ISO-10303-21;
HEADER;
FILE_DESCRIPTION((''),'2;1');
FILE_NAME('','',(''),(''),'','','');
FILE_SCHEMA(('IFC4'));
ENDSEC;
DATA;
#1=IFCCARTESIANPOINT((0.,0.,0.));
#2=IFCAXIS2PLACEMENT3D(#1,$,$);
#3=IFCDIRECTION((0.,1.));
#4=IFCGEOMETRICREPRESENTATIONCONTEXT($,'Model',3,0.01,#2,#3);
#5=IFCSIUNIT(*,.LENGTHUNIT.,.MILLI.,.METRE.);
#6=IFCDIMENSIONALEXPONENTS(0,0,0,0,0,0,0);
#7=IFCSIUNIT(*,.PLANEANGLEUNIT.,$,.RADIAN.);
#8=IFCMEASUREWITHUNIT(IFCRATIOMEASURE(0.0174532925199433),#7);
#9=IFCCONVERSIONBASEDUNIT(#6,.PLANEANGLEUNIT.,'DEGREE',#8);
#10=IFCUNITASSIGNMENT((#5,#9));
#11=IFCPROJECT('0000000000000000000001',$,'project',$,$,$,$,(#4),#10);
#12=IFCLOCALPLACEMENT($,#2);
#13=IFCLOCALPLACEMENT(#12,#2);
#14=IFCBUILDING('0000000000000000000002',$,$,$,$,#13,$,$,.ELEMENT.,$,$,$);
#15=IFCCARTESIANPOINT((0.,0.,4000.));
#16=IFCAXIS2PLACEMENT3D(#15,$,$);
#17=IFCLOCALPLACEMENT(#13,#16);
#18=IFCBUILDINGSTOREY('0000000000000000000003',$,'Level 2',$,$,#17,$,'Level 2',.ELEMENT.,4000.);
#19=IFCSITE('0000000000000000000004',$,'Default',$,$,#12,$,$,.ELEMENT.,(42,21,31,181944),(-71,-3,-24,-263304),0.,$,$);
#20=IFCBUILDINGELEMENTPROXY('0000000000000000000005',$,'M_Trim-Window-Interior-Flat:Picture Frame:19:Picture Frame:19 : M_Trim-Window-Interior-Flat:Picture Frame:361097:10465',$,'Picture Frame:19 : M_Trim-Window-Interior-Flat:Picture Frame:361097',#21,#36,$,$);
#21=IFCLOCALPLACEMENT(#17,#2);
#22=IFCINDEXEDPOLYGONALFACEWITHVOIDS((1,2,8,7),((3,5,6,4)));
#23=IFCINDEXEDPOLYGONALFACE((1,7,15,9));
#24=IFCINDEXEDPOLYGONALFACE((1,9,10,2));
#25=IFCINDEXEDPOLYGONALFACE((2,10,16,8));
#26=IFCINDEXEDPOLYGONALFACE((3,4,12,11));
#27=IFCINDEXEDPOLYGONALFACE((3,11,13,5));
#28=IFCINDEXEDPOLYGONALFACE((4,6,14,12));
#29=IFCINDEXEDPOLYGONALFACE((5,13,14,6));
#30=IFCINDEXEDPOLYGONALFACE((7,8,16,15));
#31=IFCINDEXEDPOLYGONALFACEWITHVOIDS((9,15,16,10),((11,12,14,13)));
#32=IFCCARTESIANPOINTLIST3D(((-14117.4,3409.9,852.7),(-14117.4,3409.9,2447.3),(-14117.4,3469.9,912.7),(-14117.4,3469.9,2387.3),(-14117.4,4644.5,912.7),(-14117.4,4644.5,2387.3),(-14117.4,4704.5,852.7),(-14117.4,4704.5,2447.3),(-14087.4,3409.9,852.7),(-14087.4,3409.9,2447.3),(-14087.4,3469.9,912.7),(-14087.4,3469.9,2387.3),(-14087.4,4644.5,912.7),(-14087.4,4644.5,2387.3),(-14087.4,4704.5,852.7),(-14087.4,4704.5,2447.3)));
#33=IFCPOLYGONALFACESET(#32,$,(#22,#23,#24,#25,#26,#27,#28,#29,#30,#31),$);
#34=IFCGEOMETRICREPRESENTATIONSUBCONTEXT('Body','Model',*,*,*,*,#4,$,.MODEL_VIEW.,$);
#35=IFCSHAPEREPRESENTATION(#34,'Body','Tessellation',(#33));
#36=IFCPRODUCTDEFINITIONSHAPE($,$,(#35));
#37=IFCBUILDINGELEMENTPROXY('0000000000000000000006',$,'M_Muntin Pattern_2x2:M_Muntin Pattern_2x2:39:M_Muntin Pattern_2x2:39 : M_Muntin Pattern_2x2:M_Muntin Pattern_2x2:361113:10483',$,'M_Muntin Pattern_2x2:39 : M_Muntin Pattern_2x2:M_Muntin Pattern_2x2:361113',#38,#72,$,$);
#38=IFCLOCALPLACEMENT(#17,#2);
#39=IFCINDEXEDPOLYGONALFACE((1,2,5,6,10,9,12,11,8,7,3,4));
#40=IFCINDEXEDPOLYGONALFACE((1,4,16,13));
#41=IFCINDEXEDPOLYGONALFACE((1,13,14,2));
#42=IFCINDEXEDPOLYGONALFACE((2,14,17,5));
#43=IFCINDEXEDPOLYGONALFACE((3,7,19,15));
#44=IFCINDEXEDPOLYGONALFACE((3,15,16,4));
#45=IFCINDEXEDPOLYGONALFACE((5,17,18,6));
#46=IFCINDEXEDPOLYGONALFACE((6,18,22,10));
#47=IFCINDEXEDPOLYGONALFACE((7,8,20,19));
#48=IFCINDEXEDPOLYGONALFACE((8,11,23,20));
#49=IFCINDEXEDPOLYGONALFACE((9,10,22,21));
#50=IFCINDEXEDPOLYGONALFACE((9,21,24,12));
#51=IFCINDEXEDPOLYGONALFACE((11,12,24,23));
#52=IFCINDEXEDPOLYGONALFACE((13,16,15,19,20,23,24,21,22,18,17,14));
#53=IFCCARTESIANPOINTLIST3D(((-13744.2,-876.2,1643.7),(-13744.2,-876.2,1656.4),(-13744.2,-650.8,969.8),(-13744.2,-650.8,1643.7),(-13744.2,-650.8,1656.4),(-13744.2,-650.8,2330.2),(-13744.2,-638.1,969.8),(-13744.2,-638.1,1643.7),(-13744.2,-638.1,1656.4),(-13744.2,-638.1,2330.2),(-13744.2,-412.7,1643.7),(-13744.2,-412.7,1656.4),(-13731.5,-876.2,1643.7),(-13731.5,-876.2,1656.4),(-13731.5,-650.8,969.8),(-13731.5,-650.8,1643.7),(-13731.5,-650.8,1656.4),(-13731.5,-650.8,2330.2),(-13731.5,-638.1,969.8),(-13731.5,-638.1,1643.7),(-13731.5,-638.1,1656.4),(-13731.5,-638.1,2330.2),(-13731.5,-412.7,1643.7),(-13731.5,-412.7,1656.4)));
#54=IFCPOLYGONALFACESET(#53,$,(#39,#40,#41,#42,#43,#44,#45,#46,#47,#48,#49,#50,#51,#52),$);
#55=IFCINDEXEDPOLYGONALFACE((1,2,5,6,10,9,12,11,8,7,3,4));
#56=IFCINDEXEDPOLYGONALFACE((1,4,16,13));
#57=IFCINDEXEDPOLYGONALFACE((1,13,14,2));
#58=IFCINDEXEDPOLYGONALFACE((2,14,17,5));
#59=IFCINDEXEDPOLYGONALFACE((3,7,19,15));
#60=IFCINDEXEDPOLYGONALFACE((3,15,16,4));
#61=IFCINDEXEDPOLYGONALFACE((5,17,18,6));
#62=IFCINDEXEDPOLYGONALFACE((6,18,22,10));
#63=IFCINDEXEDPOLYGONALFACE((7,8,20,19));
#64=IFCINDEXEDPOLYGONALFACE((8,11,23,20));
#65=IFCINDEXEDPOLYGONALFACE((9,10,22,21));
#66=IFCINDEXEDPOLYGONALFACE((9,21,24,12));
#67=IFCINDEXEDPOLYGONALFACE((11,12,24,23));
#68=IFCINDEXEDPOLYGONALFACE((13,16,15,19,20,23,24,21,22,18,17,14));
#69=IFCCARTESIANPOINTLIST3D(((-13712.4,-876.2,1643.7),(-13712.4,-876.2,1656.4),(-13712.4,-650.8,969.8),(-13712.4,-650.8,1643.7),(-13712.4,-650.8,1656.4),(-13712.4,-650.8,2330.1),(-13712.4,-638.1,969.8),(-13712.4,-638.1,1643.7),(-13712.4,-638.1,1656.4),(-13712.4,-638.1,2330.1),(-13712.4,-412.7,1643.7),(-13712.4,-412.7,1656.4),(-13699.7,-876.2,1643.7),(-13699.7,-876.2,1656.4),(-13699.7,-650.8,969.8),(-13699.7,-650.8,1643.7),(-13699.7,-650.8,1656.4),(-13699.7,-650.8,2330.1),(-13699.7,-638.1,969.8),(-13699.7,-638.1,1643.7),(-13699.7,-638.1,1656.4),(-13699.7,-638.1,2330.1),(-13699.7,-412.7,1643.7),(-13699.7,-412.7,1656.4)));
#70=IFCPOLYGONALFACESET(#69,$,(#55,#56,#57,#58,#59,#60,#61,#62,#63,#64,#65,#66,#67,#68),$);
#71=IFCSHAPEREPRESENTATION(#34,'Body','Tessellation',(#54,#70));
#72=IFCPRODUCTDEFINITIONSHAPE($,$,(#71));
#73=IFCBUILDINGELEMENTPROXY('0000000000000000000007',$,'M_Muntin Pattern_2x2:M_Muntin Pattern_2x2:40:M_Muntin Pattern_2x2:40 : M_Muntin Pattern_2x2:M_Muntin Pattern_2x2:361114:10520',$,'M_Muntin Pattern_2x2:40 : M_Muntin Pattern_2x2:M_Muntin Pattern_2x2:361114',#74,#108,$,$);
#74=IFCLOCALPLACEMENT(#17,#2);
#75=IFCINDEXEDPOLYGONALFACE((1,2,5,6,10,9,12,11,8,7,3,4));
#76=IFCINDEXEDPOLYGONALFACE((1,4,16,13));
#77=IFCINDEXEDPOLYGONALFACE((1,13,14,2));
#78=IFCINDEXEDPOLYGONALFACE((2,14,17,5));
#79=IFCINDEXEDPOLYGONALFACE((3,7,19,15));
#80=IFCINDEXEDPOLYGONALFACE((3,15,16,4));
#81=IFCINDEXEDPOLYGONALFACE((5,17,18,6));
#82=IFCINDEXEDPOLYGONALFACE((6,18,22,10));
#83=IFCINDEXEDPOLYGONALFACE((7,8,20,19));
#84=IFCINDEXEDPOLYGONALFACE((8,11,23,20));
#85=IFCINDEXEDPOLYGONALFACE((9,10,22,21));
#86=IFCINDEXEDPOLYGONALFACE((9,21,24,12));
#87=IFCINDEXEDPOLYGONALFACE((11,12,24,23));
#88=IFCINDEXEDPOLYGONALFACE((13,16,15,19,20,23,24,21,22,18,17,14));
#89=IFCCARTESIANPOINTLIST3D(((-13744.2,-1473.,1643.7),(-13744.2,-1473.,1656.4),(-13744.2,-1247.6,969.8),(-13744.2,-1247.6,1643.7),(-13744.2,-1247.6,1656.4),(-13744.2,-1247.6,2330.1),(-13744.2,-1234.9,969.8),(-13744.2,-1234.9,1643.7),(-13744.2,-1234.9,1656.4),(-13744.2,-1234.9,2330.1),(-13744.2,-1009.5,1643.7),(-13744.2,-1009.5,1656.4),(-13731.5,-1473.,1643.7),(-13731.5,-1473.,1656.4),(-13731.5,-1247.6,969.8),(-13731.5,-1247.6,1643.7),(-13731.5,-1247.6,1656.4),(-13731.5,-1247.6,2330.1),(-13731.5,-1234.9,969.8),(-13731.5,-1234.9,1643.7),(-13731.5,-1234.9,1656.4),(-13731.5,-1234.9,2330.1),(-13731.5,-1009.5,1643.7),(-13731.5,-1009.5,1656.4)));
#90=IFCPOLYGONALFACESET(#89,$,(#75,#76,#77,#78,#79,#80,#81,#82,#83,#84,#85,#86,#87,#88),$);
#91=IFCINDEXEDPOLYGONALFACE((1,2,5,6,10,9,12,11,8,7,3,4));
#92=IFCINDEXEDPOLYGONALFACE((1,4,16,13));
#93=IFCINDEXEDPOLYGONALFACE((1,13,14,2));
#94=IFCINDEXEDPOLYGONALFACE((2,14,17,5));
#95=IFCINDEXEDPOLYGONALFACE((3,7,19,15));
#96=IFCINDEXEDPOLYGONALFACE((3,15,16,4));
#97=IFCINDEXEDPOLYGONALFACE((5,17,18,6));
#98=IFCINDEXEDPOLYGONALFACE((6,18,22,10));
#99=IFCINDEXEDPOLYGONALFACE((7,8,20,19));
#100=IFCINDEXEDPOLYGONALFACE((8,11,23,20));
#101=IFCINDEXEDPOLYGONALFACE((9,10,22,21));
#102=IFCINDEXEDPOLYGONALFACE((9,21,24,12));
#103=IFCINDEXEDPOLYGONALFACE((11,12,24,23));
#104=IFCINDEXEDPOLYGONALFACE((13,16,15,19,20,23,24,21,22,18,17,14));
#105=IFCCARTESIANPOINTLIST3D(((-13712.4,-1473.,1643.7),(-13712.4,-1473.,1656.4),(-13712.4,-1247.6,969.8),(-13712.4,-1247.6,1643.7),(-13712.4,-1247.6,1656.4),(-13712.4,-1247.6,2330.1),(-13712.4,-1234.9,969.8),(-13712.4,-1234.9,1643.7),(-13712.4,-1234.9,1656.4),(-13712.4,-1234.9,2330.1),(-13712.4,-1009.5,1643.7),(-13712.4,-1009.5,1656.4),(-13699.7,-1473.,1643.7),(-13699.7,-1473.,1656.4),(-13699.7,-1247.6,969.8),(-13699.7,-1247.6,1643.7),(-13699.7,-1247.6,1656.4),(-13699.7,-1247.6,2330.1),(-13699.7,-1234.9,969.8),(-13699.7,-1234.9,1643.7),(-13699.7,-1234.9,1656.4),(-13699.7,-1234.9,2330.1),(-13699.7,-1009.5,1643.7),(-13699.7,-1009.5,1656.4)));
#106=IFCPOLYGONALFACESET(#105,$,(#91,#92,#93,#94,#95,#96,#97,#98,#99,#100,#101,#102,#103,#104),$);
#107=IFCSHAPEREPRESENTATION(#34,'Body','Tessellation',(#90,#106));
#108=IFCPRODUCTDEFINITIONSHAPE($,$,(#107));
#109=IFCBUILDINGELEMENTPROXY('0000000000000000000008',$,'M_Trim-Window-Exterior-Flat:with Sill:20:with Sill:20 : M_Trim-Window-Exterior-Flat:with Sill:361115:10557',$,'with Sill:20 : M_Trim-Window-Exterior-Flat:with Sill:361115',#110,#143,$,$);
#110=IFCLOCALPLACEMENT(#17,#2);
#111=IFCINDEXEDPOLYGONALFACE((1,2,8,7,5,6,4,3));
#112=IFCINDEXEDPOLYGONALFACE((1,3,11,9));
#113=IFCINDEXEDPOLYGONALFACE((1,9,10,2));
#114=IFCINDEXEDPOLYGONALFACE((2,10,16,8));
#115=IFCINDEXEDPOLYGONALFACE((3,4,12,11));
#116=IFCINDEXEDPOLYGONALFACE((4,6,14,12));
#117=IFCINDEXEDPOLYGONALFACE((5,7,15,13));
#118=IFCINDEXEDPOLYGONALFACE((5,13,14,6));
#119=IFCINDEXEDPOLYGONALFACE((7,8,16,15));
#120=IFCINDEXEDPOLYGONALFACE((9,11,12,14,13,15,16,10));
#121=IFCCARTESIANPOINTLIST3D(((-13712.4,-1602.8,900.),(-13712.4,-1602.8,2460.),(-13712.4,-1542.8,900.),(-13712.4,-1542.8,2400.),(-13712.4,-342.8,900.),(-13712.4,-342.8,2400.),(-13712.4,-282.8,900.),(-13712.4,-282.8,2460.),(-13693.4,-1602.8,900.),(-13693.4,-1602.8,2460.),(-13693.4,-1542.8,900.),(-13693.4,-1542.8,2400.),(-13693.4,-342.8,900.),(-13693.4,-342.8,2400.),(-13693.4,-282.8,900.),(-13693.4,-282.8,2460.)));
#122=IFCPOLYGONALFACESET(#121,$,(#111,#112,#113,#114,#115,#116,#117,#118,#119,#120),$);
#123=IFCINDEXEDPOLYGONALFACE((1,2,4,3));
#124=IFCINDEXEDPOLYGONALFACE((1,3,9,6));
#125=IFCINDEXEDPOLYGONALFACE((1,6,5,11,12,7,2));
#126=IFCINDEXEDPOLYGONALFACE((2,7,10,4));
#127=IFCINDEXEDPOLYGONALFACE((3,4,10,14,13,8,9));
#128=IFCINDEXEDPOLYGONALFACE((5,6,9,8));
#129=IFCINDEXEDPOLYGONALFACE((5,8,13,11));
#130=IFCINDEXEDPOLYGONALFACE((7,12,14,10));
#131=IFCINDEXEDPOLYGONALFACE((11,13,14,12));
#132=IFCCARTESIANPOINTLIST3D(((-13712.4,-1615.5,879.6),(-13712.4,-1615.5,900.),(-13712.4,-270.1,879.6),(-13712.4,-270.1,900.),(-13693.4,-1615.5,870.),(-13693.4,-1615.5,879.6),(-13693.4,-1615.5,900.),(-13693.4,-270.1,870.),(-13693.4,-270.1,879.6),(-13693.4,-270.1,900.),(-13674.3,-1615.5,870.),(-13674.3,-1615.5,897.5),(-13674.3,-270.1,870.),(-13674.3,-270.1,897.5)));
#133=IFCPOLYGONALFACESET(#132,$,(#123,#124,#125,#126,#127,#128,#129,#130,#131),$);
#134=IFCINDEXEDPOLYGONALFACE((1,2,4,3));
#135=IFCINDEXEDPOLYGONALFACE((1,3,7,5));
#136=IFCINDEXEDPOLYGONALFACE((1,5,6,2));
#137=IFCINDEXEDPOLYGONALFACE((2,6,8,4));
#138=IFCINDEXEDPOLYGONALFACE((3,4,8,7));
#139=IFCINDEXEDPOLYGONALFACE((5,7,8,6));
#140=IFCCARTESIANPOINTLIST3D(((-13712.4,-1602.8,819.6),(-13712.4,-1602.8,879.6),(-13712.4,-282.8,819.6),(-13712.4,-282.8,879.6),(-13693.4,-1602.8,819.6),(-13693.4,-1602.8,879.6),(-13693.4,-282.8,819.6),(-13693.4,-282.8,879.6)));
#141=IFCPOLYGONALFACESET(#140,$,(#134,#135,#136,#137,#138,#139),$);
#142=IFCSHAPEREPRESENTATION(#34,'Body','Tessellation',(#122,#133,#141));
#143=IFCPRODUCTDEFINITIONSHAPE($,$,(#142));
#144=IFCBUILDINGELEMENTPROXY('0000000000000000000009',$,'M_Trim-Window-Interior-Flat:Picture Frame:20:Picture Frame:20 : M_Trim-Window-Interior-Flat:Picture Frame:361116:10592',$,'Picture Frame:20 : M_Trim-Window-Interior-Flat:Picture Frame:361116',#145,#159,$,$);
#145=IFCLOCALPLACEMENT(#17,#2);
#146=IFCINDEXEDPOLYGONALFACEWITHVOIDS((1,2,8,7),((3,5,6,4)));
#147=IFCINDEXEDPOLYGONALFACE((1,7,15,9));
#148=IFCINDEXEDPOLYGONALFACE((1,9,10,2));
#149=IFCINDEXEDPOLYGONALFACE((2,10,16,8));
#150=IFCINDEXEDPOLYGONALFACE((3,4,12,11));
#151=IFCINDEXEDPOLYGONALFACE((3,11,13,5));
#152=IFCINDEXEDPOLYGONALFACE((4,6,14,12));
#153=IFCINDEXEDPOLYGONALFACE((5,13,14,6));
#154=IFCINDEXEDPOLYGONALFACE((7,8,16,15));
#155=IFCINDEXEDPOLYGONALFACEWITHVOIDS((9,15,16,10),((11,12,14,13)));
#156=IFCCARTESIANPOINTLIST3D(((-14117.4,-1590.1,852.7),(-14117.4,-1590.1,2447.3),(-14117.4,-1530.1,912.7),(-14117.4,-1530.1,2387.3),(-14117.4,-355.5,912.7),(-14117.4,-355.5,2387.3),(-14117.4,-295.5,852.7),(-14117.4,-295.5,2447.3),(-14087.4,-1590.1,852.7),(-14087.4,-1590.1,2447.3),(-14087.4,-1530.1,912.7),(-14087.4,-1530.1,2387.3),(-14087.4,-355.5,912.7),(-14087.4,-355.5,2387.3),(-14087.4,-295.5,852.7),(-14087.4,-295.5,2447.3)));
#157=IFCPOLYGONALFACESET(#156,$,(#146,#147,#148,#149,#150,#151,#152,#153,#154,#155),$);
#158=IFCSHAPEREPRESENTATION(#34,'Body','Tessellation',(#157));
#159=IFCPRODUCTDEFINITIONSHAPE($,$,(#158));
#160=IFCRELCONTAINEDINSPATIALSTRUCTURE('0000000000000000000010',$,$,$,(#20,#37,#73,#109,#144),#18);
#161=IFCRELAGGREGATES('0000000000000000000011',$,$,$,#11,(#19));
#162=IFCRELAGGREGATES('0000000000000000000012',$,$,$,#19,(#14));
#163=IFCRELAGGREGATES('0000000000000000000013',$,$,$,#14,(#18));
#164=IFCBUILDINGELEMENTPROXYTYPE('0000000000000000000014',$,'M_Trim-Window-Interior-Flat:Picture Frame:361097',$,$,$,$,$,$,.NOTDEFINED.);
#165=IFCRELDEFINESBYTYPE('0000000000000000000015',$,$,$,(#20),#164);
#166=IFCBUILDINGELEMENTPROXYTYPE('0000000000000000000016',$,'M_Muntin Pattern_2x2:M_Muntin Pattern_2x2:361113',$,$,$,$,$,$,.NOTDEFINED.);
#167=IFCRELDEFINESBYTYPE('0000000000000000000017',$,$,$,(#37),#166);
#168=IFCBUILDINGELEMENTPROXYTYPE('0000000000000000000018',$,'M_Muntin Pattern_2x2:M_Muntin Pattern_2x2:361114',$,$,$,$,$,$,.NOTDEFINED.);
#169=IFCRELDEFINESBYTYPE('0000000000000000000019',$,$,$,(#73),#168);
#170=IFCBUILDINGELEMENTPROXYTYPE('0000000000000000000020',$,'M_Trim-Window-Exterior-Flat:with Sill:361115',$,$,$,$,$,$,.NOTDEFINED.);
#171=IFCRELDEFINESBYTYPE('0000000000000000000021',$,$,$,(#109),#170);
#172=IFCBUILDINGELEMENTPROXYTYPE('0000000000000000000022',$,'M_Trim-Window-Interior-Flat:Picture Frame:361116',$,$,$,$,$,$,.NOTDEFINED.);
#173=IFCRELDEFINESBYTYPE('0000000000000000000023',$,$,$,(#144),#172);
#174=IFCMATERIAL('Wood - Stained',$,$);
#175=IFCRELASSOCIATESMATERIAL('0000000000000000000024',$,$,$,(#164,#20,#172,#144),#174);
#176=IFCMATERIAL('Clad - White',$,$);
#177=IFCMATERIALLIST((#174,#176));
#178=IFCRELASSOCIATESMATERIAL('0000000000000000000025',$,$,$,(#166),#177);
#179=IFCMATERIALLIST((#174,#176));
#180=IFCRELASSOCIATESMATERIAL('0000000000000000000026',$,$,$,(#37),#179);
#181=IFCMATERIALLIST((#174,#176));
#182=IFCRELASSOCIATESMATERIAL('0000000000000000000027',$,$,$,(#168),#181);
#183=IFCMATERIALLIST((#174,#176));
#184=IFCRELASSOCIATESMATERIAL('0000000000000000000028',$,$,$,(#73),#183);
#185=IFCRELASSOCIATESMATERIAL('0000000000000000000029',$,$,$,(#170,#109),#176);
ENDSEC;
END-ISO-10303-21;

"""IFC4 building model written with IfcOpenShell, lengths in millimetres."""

from ifc_helpers import new_model, entity, si_unit, converted_unit, direction, frame, origin, origin_2d_with_axis, place, context, subcontext, project, spatial, polyline, rectangle, outline, extrude, source, transform, mapped, material, material_list, type_object, type_shapes, element, save


model = new_model("IFC4")

# Units and contexts
model_context = context("Model", 3, precision=0.01, world=origin(), true_north=direction((0.0, 1.0)))
body_context = subcontext(model_context, "Body", "Model", "MODEL_VIEW")
ifc_project = project(units=[si_unit("LENGTHUNIT", "METRE", prefix="MILLI"), converted_unit("PLANEANGLEUNIT", "DEGREE", entity("IfcRatioMeasure", 0.0174532925199433), si_unit("PLANEANGLEUNIT", "RADIAN"), dimensions=[0, 0, 0, 0, 0, 0, 0])], contexts=[model_context])

# Site, building, storey
site_placement = place(None, origin())
site = spatial("IfcSite", under=ifc_project, at=site_placement, Name="Default", CompositionType="ELEMENT", RefLatitude=(42, 21, 31, 181944), RefLongitude=(-71, -3, -24, -263304), RefElevation=0.0)
building_placement = place(site_placement, origin())
building = spatial("IfcBuilding", under=site, at=building_placement, CompositionType="ELEMENT")
storey_placement = place(building_placement, frame((0.0, 0.0, 4000.0)))
storey = spatial("IfcBuildingStorey", under=building, at=storey_placement, Name="Level 2", LongName="Level 2", CompositionType="ELEMENT", Elevation=4000.0)

# Building element proxies
ifc_material_1 = material(Name="Wood - Stained")
building_element_proxy_type_1 = type_object("IfcBuildingElementProxyType", Name="M_Trim-Window-Interior-Flat:Picture Frame:361097", PredefinedType="NOTDEFINED", material=ifc_material_1)
shared_shape_1 = source(origin(), body_context, "Body", "SweptSolid", [
    extrude(outline(polyline([(-647.3, -797.3), (647.3, -797.3), (647.3, 797.3), (-647.3, 797.3), (-647.3, -797.3)]), holes=[polyline([(587.3, 737.3), (587.3, -737.3), (-587.3, -737.3), (-587.3, 737.3), (587.3, 737.3)])]), frame((-14117.4, 4057.2, 5650.0), z_axis=(1.0, 0.0, 0.0), x_axis=(0.0, -1.0, 0.0)), (0.0, 0.0, 1.0), 30.0),
])
type_shapes(building_element_proxy_type_1, [shared_shape_1])
proxy_1_placement = place(storey_placement, frame((0.0, 0.0, -4000.0)))
element("IfcBuildingElementProxy", 1, at=proxy_1_placement, inside=storey, type_object=building_element_proxy_type_1, material=ifc_material_1, Name="M_Trim-Window-Interior-Flat:Picture Frame:19:Picture Frame:19 : M_Trim-Window-Interior-Flat:Picture Frame:361097:10465", ObjectType="Picture Frame:19 : M_Trim-Window-Interior-Flat:Picture Frame:361097", context=body_context, shape_type="MappedRepresentation", body=[
    mapped(shared_shape_1, transform((0.0, 0.0, 0.0), scale=1.0)),
])
ifc_material_2 = material(Name="Clad - White")
ifc_material_list_1 = material_list([ifc_material_1, ifc_material_2])
ifc_material_list_2 = material_list([ifc_material_1, ifc_material_2])
building_element_proxy_type_2 = type_object("IfcBuildingElementProxyType", Name="M_Muntin Pattern_2x2:M_Muntin Pattern_2x2:361113", PredefinedType="NOTDEFINED", material=ifc_material_list_2)
shared_shape_2 = source(origin(), body_context, "Body", "SweptSolid", [
    extrude(outline(polyline([(-6.4, -680.2), (6.3, -680.2), (6.3, -6.4), (231.7, -6.4), (231.7, 6.3), (6.3, 6.3), (6.3, 680.2), (-6.4, 680.2), (-6.4, 6.3), (-231.7, 6.3), (-231.7, -6.4), (-6.4, -6.4), (-6.4, -680.2)])), frame((-13744.2, -644.4, 5650.0), z_axis=(1.0, 0.0, 0.0), x_axis=(0.0, -1.0, 0.0)), (0.0, 0.0, 1.0), 12.7),
    extrude(outline(polyline([(-6.4, -680.1), (6.3, -680.1), (6.3, -6.4), (231.7, -6.4), (231.7, 6.3), (6.3, 6.3), (6.3, 680.2), (-6.4, 680.2), (-6.4, 6.3), (-231.7, 6.3), (-231.7, -6.4), (-6.4, -6.4), (-6.4, -680.1)])), frame((-13712.4, -644.4, 5650.0), z_axis=(1.0, 0.0, 0.0), x_axis=(0.0, -1.0, 0.0)), (0.0, 0.0, 1.0), 12.7),
])
type_shapes(building_element_proxy_type_2, [shared_shape_2])
proxy_2_placement = place(storey_placement, frame((0.0, 0.0, -4000.0)))
element("IfcBuildingElementProxy", 2, at=proxy_2_placement, inside=storey, type_object=building_element_proxy_type_2, material=ifc_material_list_1, Name="M_Muntin Pattern_2x2:M_Muntin Pattern_2x2:39:M_Muntin Pattern_2x2:39 : M_Muntin Pattern_2x2:M_Muntin Pattern_2x2:361113:10483", ObjectType="M_Muntin Pattern_2x2:39 : M_Muntin Pattern_2x2:M_Muntin Pattern_2x2:361113", context=body_context, shape_type="MappedRepresentation", body=[
    mapped(shared_shape_2, transform((0.0, 0.0, 0.0), scale=1.0)),
])
ifc_material_list_3 = material_list([ifc_material_1, ifc_material_2])
ifc_material_list_4 = material_list([ifc_material_1, ifc_material_2])
building_element_proxy_type_3 = type_object("IfcBuildingElementProxyType", Name="M_Muntin Pattern_2x2:M_Muntin Pattern_2x2:361114", PredefinedType="NOTDEFINED", material=ifc_material_list_4)
shared_shape_3 = source(origin(), body_context, "Body", "SweptSolid", [
    extrude(outline(polyline([(-680.1, 6.4), (-680.1, -6.3), (-6.4, -6.3), (-6.4, -231.7), (6.3, -231.7), (6.3, -6.3), (680.2, -6.3), (680.2, 6.4), (6.3, 6.4), (6.3, 231.7), (-6.4, 231.7), (-6.4, 6.4), (-680.1, 6.4)])), frame((-13744.2, -1241.3, 5650.0), z_axis=(-1.0, 0.0, 0.0), x_axis=(0.0, 0.0, -1.0)), (0.0, 0.0, -1.0), 12.7),
    extrude(outline(polyline([(-680.1, 6.4), (-680.1, -6.3), (-6.4, -6.3), (-6.4, -231.7), (6.3, -231.7), (6.3, -6.3), (680.2, -6.3), (680.2, 6.4), (6.3, 6.4), (6.3, 231.7), (-6.4, 231.7), (-6.4, 6.4), (-680.1, 6.4)])), frame((-13712.4, -1241.3, 5650.0), z_axis=(-1.0, 0.0, 0.0), x_axis=(0.0, 0.0, -1.0)), (0.0, 0.0, -1.0), 12.7),
])
type_shapes(building_element_proxy_type_3, [shared_shape_3])
proxy_3_placement = place(storey_placement, frame((0.0, 0.0, -4000.0)))
element("IfcBuildingElementProxy", 3, at=proxy_3_placement, inside=storey, type_object=building_element_proxy_type_3, material=ifc_material_list_3, Name="M_Muntin Pattern_2x2:M_Muntin Pattern_2x2:40:M_Muntin Pattern_2x2:40 : M_Muntin Pattern_2x2:M_Muntin Pattern_2x2:361114:10520", ObjectType="M_Muntin Pattern_2x2:40 : M_Muntin Pattern_2x2:M_Muntin Pattern_2x2:361114", context=body_context, shape_type="MappedRepresentation", body=[
    mapped(shared_shape_3, transform((0.0, 0.0, 0.0), scale=1.0)),
])
building_element_proxy_type_4 = type_object("IfcBuildingElementProxyType", Name="M_Trim-Window-Exterior-Flat:with Sill:361115", PredefinedType="NOTDEFINED", material=ifc_material_2)
shared_shape_4 = source(origin(), body_context, "Body", "SweptSolid", [
    extrude(outline(polyline([(-660.0, -765.0), (-600.0, -765.0), (-600.0, 735.0), (600.0, 735.0), (600.0, -765.0), (660.0, -765.0), (660.0, 795.0), (-660.0, 795.0), (-660.0, -765.0)])), frame((-13712.4, -942.8, 5665.0), z_axis=(1.0, 0.0, 0.0), x_axis=(0.0, 1.0, 0.0)), (0.0, 0.0, 1.0), 19.1),
    extrude(outline(polyline([(-15.2, 0.0), (-15.2, -19.0), (12.3, -19.0), (14.8, 0.0), (14.8, 19.0), (-5.7, 19.0), (-5.7, 0.0), (-15.2, 0.0)])), frame((-13693.4, -1615.5, 4885.2), z_axis=(0.0, -1.0, 0.0), x_axis=(0.0, 0.0, 1.0)), (0.0, 0.0, -1.0), 1345.4),
    extrude(rectangle(XDim=19.1, YDim=1320.0, at=origin_2d_with_axis()), frame((-13702.9, -942.8, 4819.6), z_axis=(0.0, 0.0, 1.0), x_axis=(-1.0, 0.0, 0.0)), (0.0, 0.0, 1.0), 60.0),
])
type_shapes(building_element_proxy_type_4, [shared_shape_4])
proxy_4_placement = place(storey_placement, frame((0.0, 0.0, -4000.0)))
element("IfcBuildingElementProxy", 4, at=proxy_4_placement, inside=storey, type_object=building_element_proxy_type_4, material=ifc_material_2, Name="M_Trim-Window-Exterior-Flat:with Sill:20:with Sill:20 : M_Trim-Window-Exterior-Flat:with Sill:361115:10557", ObjectType="with Sill:20 : M_Trim-Window-Exterior-Flat:with Sill:361115", context=body_context, shape_type="MappedRepresentation", body=[
    mapped(shared_shape_4, transform((0.0, 0.0, 0.0), scale=1.0)),
])
building_element_proxy_type_5 = type_object("IfcBuildingElementProxyType", Name="M_Trim-Window-Interior-Flat:Picture Frame:361116", PredefinedType="NOTDEFINED", material=ifc_material_1)
shared_shape_5 = source(origin(), body_context, "Body", "SweptSolid", [
    extrude(outline(polyline([(-647.3, -797.3), (647.3, -797.3), (647.3, 797.3), (-647.3, 797.3), (-647.3, -797.3)]), holes=[polyline([(587.3, 737.3), (587.3, -737.3), (-587.3, -737.3), (-587.3, 737.3), (587.3, 737.3)])]), frame((-14117.4, -942.8, 5650.0), z_axis=(1.0, 0.0, 0.0), x_axis=(0.0, -1.0, 0.0)), (0.0, 0.0, 1.0), 30.0),
])
type_shapes(building_element_proxy_type_5, [shared_shape_5])
proxy_5_placement = place(storey_placement, frame((0.0, 0.0, -4000.0)))
element("IfcBuildingElementProxy", 5, at=proxy_5_placement, inside=storey, type_object=building_element_proxy_type_5, material=ifc_material_1, Name="M_Trim-Window-Interior-Flat:Picture Frame:20:Picture Frame:20 : M_Trim-Window-Interior-Flat:Picture Frame:361116:10592", ObjectType="Picture Frame:20 : M_Trim-Window-Interior-Flat:Picture Frame:361116", context=body_context, shape_type="MappedRepresentation", body=[
    mapped(shared_shape_5, transform((0.0, 0.0, 0.0), scale=1.0)),
])

save(model, "model.ifc")
